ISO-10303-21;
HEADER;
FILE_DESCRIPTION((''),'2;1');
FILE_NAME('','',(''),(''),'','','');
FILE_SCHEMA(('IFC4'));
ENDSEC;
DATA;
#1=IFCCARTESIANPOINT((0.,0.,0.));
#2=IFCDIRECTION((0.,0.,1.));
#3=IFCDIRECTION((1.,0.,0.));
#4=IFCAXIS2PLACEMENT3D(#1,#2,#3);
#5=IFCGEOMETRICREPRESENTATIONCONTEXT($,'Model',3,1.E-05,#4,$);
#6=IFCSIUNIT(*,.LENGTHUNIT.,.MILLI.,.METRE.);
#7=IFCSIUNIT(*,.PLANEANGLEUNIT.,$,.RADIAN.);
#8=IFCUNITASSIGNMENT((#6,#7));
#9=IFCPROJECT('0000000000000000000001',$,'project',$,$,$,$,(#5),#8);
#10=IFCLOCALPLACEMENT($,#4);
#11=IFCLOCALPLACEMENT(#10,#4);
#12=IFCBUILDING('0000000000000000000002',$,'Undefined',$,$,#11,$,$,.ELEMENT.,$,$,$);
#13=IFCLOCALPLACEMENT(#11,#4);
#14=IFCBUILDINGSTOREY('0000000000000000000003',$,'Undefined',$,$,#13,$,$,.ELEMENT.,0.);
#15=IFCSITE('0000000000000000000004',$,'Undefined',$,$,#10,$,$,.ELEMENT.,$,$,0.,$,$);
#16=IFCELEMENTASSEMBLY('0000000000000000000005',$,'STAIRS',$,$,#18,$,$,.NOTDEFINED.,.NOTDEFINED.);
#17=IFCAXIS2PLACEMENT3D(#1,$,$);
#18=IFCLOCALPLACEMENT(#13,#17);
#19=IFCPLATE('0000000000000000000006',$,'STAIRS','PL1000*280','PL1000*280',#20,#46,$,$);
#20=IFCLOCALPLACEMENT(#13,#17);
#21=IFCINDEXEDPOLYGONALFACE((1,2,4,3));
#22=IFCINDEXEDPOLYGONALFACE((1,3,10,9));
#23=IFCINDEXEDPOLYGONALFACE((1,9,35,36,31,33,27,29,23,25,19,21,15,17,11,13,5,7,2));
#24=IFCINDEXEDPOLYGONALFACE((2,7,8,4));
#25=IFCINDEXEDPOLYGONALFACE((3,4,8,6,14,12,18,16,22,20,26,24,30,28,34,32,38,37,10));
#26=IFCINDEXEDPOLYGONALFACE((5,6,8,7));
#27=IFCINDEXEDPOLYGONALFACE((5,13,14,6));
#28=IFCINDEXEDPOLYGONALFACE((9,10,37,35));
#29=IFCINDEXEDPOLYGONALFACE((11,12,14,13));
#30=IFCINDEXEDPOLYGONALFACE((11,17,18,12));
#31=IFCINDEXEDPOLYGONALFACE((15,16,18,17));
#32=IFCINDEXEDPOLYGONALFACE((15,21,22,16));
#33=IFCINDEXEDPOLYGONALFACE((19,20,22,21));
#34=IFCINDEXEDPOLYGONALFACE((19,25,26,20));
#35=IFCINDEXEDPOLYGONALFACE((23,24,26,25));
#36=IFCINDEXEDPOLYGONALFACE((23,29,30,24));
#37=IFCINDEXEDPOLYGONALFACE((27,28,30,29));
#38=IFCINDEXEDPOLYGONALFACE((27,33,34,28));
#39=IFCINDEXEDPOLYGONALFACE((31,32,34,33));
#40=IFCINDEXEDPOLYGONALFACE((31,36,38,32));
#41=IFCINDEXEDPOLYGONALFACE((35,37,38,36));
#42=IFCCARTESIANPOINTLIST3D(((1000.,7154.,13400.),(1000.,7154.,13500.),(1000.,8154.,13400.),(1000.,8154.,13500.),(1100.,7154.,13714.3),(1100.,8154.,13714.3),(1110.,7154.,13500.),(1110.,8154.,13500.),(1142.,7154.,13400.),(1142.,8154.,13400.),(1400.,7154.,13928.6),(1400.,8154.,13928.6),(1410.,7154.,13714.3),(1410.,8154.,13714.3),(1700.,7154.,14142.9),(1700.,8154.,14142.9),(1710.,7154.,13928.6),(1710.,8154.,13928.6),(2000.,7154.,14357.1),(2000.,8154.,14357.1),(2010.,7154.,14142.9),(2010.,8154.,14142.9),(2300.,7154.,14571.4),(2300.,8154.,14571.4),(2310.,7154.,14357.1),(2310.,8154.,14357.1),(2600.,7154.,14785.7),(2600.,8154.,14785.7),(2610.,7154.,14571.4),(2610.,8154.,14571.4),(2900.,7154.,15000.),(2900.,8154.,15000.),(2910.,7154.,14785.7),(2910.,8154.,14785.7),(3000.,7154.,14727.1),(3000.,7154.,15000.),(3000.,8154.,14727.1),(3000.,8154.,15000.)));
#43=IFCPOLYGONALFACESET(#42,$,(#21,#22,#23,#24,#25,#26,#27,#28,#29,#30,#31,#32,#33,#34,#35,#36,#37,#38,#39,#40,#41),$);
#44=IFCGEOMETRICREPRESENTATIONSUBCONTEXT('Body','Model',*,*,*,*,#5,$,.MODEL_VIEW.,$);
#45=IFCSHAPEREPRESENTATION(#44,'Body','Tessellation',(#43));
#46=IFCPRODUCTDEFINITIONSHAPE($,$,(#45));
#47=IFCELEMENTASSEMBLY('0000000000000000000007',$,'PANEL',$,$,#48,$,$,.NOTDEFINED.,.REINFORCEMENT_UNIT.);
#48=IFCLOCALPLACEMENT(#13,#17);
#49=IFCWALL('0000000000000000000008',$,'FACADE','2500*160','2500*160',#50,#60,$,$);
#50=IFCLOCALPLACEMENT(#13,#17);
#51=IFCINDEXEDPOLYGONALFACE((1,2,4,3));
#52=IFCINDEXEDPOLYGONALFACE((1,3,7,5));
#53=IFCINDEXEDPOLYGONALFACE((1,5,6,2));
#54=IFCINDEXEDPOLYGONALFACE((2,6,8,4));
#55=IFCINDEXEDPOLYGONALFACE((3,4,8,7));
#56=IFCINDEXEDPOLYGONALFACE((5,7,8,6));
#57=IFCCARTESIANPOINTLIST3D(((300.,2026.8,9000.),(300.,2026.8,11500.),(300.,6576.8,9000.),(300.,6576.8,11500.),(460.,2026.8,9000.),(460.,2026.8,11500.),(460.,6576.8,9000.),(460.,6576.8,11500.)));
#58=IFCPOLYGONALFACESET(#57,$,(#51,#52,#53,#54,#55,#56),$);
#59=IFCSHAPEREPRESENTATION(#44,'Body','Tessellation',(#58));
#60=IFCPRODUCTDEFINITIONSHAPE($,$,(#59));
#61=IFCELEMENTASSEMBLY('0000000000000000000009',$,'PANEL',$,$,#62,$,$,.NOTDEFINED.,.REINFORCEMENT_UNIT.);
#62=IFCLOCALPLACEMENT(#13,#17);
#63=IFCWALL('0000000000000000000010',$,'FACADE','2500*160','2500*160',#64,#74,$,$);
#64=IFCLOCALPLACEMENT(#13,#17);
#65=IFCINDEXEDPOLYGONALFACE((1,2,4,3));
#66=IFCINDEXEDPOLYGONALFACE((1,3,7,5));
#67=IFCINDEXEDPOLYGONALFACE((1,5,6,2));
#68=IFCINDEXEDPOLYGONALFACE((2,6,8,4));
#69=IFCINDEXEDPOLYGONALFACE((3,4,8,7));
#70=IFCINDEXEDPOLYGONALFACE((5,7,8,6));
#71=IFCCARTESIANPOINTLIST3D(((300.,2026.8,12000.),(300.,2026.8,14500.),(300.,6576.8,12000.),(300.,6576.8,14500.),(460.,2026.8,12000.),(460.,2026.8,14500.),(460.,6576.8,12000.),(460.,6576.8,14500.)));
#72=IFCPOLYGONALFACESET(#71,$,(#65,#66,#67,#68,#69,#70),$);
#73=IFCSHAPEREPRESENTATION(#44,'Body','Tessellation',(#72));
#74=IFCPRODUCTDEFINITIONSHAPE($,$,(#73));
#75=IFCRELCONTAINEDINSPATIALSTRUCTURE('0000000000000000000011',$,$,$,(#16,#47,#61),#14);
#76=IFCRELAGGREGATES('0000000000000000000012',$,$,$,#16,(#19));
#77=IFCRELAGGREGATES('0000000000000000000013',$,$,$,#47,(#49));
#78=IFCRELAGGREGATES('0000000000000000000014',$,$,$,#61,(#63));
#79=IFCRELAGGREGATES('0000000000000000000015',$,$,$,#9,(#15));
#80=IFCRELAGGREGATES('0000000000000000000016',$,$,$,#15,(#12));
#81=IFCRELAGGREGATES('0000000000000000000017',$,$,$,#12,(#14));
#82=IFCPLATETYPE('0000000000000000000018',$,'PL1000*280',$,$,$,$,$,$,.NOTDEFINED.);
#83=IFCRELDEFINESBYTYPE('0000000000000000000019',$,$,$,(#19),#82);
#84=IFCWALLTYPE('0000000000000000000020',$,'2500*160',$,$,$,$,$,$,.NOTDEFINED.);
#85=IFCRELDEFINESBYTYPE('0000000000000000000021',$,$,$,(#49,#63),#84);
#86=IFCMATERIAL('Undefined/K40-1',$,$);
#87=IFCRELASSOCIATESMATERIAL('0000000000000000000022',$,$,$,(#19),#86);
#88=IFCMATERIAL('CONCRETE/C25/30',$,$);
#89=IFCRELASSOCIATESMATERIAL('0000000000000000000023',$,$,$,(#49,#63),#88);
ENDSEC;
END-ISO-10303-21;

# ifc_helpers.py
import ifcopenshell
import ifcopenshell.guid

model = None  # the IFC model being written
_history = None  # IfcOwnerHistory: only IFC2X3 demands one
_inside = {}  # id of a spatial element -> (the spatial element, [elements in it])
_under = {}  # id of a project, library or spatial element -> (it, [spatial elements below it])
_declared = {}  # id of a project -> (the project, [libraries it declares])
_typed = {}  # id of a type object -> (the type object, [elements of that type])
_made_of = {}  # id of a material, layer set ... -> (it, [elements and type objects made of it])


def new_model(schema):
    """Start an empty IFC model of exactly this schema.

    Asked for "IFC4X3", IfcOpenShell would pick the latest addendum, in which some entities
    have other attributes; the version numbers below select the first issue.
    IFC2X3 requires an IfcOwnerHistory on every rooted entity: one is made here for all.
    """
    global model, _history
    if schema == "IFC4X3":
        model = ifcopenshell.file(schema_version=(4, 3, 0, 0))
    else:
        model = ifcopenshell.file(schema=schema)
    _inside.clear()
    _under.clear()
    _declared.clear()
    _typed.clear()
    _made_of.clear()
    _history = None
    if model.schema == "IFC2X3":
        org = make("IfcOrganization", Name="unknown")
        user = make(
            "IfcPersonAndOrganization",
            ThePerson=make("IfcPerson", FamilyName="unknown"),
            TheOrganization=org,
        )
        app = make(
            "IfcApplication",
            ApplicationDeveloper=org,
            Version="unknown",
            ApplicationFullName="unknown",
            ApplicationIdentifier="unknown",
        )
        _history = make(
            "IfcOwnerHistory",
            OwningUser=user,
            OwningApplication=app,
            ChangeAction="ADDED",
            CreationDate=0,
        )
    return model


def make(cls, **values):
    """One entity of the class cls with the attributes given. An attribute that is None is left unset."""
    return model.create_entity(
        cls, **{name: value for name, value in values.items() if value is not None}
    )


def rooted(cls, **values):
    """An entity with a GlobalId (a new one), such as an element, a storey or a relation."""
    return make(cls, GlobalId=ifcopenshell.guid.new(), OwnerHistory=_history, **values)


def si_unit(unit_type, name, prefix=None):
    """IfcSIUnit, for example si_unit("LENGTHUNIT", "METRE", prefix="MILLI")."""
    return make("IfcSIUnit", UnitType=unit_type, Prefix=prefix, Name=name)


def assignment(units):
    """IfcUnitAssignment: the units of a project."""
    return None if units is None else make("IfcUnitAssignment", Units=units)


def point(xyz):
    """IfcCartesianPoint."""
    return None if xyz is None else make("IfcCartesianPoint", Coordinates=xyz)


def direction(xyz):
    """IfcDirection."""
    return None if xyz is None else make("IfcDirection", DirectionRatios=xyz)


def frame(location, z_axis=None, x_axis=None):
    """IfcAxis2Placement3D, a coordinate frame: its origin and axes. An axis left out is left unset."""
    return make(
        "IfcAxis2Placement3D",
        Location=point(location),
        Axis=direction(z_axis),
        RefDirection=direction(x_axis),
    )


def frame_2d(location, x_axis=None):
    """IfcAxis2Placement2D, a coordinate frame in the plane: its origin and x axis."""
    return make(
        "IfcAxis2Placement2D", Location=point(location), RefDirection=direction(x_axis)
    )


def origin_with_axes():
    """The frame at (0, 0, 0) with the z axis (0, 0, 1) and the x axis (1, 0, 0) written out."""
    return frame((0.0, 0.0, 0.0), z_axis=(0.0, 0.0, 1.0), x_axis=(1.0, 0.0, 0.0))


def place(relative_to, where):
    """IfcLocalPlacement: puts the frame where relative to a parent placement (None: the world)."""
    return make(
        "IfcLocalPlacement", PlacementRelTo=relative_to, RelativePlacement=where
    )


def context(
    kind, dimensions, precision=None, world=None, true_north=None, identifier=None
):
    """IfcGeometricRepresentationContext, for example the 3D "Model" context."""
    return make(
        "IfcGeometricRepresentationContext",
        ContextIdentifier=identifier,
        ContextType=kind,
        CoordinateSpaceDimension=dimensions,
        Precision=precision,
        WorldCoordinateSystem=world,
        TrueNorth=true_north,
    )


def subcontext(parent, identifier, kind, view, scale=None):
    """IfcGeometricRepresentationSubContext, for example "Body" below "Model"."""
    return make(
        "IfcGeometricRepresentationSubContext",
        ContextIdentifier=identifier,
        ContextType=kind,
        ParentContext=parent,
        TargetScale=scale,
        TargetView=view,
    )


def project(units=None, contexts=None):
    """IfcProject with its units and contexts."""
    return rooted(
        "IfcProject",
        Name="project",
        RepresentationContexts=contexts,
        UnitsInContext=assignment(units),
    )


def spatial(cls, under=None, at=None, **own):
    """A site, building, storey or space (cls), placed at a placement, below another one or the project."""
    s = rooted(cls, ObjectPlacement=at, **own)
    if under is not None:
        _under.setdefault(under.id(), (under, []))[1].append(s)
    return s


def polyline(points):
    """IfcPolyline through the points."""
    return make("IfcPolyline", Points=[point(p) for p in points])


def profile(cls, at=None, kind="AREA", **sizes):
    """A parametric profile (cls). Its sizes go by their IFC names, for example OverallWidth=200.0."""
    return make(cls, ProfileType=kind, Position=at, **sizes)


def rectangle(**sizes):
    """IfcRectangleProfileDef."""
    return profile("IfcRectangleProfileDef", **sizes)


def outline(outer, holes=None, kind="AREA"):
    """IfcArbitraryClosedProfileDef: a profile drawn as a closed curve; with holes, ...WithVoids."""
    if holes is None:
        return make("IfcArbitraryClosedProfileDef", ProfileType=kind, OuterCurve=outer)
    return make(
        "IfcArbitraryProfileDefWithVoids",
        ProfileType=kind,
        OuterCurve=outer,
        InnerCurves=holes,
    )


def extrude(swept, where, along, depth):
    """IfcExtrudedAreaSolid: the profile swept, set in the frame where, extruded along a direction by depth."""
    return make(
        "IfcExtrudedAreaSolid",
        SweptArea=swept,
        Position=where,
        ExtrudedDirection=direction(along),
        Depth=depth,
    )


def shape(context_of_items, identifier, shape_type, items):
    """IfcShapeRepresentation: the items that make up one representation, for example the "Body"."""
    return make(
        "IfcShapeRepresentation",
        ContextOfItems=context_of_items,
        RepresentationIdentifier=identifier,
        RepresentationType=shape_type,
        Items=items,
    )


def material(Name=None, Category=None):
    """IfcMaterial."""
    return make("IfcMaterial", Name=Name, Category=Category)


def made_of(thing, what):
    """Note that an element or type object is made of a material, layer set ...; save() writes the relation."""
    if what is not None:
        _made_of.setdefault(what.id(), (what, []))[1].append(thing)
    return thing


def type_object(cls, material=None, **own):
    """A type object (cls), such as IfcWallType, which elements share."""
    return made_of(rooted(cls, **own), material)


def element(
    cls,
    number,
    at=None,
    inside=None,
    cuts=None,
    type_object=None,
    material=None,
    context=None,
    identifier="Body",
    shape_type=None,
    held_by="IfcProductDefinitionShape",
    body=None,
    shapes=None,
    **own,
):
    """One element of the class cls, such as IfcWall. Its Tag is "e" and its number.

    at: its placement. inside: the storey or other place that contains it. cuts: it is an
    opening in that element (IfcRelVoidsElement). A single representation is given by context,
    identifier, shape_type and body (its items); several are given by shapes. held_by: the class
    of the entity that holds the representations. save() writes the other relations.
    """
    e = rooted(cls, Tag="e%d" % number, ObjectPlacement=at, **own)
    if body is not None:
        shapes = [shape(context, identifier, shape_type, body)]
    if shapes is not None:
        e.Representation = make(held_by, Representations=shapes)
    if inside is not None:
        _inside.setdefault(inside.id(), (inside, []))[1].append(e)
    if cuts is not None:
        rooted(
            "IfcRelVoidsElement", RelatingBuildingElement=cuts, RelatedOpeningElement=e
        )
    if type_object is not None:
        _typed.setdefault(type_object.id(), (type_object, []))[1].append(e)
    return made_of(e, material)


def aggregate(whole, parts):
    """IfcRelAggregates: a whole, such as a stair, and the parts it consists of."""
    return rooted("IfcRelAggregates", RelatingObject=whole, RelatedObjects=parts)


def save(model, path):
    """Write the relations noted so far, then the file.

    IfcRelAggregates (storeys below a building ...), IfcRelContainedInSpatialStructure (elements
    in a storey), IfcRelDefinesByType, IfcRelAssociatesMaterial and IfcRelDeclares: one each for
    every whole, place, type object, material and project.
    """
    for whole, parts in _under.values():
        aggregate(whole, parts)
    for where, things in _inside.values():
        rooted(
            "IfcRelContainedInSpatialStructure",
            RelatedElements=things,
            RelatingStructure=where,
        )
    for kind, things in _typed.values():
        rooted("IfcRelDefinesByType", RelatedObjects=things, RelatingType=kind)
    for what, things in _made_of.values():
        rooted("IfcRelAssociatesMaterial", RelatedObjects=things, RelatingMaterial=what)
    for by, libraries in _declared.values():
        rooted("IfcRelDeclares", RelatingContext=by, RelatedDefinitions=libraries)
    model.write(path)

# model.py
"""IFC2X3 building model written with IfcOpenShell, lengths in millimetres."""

from ifc_helpers import new_model, si_unit, frame, frame_2d, origin_with_axes, place, context, subcontext, project, spatial, polyline, rectangle, outline, extrude, material, type_object, element, aggregate, save


model = new_model("IFC2X3")

# Units and contexts
model_context = context("Model", 3, precision=1e-05, world=origin_with_axes())
body_context = subcontext(model_context, "Body", "Model", "MODEL_VIEW")
ifc_project = project(units=[si_unit("LENGTHUNIT", "METRE", prefix="MILLI"), si_unit("PLANEANGLEUNIT", "RADIAN")], contexts=[model_context])

# Site, building, storey
site_placement = place(None, origin_with_axes())
site = spatial("IfcSite", under=ifc_project, at=site_placement, Name="Undefined", CompositionType="ELEMENT", RefElevation=0.0)
building_placement = place(site_placement, origin_with_axes())
building = spatial("IfcBuilding", under=site, at=building_placement, Name="Undefined", CompositionType="ELEMENT")
storey_placement = place(building_placement, origin_with_axes())
storey = spatial("IfcBuildingStorey", under=building, at=storey_placement, Name="Undefined", CompositionType="ELEMENT", Elevation=0.0)

# Shared definitions
ifc_material_1 = material(Name="CONCRETE/C25/30")

# Element assembly, plate
ifc_material_2 = material(Name="Undefined/K40-1")
plate_type_1 = type_object("IfcPlateType", Name="PL1000*280", PredefinedType="NOTDEFINED")
assembly_1_placement = place(storey_placement, origin_with_axes())
assembly_1 = element("IfcElementAssembly", 1, at=assembly_1_placement, inside=storey, Name="STAIRS", AssemblyPlace="NOTDEFINED", PredefinedType="NOTDEFINED")
plate_1_placement = place(assembly_1_placement, frame((1110.0, 7654.0, 13500.0), z_axis=(0.0, -1.0, 0.0), x_axis=(-1.0, 0.0, 0.0)))
plate_1 = element("IfcPlate", 2, at=plate_1_placement, type_object=plate_type_1, material=ifc_material_2, Name="STAIRS", Description="PL1000*280", ObjectType="PL1000*280", context=body_context, shape_type="SweptSolid", body=[
    extrude(outline(polyline([(0.0, 0.0), (110.0, 0.0), (110.0, 100.0), (-32.0, 100.0), (-1890.0, -1227.1), (-1890.0, -1500.0), (-1790.0, -1500.0), (-1800.0, -1285.7), (-1490.0, -1285.7), (-1500.0, -1071.4), (-1190.0, -1071.4), (-1200.0, -857.1), (-890.0, -857.1), (-900.0, -642.9), (-590.0, -642.9), (-600.0, -428.6), (-290.0, -428.6), (-300.0, -214.3), (10.0, -214.3), (0.0, 0.0), (0.0, 0.0)])), frame((0.0, 0.0, -500.0), z_axis=(0.0, 0.0, 1.0), x_axis=(1.0, 0.0, 0.0)), (0.0, 0.0, 1.0), 1000.0),
])
aggregate(assembly_1, [plate_1])

# Element assemblies, walls
assembly_2_placement = place(storey_placement, origin_with_axes())
assembly_2 = element("IfcElementAssembly", 3, at=assembly_2_placement, inside=storey, Name="PANEL", AssemblyPlace="NOTDEFINED", PredefinedType="REINFORCEMENT_UNIT")
wall_type = type_object("IfcWallType", Name="2500*160", PredefinedType="NOTDEFINED")
wall_1_placement = place(assembly_2_placement, frame((380.0, 6576.8, 9000.0), z_axis=(0.0, 0.0, 1.0), x_axis=(0.0, -1.0, 0.0)))
wall_1 = element("IfcWall", 4, at=wall_1_placement, type_object=wall_type, material=ifc_material_1, Name="FACADE", Description="2500*160", ObjectType="2500*160", context=body_context, shape_type="SweptSolid", body=[
    extrude(rectangle(XDim=4550.0, YDim=160.0, at=frame_2d((0.0, 2275.0), x_axis=(0.0, -1.0))), frame((0.0, 0.0, 0.0), z_axis=(0.0, 0.0, 1.0), x_axis=(0.0, -1.0, 0.0)), (0.0, 0.0, 1.0), 2500.0),
])
aggregate(assembly_2, [wall_1])
assembly_3_placement = place(storey_placement, origin_with_axes())
assembly_3 = element("IfcElementAssembly", 5, at=assembly_3_placement, inside=storey, Name="PANEL", AssemblyPlace="NOTDEFINED", PredefinedType="REINFORCEMENT_UNIT")
wall_2_placement = place(assembly_3_placement, frame((380.0, 6576.8, 12000.0), z_axis=(0.0, 0.0, 1.0), x_axis=(0.0, -1.0, 0.0)))
wall_2 = element("IfcWall", 6, at=wall_2_placement, type_object=wall_type, material=ifc_material_1, Name="FACADE", Description="2500*160", ObjectType="2500*160", context=body_context, shape_type="SweptSolid", body=[
    extrude(rectangle(XDim=4550.0, YDim=160.0, at=frame_2d((0.0, 2275.0), x_axis=(0.0, -1.0))), frame((0.0, 0.0, 0.0), z_axis=(0.0, 0.0, 1.0), x_axis=(0.0, -1.0, 0.0)), (0.0, 0.0, 1.0), 2500.0),
])
aggregate(assembly_3, [wall_2])

save(model, "model.ifc")
